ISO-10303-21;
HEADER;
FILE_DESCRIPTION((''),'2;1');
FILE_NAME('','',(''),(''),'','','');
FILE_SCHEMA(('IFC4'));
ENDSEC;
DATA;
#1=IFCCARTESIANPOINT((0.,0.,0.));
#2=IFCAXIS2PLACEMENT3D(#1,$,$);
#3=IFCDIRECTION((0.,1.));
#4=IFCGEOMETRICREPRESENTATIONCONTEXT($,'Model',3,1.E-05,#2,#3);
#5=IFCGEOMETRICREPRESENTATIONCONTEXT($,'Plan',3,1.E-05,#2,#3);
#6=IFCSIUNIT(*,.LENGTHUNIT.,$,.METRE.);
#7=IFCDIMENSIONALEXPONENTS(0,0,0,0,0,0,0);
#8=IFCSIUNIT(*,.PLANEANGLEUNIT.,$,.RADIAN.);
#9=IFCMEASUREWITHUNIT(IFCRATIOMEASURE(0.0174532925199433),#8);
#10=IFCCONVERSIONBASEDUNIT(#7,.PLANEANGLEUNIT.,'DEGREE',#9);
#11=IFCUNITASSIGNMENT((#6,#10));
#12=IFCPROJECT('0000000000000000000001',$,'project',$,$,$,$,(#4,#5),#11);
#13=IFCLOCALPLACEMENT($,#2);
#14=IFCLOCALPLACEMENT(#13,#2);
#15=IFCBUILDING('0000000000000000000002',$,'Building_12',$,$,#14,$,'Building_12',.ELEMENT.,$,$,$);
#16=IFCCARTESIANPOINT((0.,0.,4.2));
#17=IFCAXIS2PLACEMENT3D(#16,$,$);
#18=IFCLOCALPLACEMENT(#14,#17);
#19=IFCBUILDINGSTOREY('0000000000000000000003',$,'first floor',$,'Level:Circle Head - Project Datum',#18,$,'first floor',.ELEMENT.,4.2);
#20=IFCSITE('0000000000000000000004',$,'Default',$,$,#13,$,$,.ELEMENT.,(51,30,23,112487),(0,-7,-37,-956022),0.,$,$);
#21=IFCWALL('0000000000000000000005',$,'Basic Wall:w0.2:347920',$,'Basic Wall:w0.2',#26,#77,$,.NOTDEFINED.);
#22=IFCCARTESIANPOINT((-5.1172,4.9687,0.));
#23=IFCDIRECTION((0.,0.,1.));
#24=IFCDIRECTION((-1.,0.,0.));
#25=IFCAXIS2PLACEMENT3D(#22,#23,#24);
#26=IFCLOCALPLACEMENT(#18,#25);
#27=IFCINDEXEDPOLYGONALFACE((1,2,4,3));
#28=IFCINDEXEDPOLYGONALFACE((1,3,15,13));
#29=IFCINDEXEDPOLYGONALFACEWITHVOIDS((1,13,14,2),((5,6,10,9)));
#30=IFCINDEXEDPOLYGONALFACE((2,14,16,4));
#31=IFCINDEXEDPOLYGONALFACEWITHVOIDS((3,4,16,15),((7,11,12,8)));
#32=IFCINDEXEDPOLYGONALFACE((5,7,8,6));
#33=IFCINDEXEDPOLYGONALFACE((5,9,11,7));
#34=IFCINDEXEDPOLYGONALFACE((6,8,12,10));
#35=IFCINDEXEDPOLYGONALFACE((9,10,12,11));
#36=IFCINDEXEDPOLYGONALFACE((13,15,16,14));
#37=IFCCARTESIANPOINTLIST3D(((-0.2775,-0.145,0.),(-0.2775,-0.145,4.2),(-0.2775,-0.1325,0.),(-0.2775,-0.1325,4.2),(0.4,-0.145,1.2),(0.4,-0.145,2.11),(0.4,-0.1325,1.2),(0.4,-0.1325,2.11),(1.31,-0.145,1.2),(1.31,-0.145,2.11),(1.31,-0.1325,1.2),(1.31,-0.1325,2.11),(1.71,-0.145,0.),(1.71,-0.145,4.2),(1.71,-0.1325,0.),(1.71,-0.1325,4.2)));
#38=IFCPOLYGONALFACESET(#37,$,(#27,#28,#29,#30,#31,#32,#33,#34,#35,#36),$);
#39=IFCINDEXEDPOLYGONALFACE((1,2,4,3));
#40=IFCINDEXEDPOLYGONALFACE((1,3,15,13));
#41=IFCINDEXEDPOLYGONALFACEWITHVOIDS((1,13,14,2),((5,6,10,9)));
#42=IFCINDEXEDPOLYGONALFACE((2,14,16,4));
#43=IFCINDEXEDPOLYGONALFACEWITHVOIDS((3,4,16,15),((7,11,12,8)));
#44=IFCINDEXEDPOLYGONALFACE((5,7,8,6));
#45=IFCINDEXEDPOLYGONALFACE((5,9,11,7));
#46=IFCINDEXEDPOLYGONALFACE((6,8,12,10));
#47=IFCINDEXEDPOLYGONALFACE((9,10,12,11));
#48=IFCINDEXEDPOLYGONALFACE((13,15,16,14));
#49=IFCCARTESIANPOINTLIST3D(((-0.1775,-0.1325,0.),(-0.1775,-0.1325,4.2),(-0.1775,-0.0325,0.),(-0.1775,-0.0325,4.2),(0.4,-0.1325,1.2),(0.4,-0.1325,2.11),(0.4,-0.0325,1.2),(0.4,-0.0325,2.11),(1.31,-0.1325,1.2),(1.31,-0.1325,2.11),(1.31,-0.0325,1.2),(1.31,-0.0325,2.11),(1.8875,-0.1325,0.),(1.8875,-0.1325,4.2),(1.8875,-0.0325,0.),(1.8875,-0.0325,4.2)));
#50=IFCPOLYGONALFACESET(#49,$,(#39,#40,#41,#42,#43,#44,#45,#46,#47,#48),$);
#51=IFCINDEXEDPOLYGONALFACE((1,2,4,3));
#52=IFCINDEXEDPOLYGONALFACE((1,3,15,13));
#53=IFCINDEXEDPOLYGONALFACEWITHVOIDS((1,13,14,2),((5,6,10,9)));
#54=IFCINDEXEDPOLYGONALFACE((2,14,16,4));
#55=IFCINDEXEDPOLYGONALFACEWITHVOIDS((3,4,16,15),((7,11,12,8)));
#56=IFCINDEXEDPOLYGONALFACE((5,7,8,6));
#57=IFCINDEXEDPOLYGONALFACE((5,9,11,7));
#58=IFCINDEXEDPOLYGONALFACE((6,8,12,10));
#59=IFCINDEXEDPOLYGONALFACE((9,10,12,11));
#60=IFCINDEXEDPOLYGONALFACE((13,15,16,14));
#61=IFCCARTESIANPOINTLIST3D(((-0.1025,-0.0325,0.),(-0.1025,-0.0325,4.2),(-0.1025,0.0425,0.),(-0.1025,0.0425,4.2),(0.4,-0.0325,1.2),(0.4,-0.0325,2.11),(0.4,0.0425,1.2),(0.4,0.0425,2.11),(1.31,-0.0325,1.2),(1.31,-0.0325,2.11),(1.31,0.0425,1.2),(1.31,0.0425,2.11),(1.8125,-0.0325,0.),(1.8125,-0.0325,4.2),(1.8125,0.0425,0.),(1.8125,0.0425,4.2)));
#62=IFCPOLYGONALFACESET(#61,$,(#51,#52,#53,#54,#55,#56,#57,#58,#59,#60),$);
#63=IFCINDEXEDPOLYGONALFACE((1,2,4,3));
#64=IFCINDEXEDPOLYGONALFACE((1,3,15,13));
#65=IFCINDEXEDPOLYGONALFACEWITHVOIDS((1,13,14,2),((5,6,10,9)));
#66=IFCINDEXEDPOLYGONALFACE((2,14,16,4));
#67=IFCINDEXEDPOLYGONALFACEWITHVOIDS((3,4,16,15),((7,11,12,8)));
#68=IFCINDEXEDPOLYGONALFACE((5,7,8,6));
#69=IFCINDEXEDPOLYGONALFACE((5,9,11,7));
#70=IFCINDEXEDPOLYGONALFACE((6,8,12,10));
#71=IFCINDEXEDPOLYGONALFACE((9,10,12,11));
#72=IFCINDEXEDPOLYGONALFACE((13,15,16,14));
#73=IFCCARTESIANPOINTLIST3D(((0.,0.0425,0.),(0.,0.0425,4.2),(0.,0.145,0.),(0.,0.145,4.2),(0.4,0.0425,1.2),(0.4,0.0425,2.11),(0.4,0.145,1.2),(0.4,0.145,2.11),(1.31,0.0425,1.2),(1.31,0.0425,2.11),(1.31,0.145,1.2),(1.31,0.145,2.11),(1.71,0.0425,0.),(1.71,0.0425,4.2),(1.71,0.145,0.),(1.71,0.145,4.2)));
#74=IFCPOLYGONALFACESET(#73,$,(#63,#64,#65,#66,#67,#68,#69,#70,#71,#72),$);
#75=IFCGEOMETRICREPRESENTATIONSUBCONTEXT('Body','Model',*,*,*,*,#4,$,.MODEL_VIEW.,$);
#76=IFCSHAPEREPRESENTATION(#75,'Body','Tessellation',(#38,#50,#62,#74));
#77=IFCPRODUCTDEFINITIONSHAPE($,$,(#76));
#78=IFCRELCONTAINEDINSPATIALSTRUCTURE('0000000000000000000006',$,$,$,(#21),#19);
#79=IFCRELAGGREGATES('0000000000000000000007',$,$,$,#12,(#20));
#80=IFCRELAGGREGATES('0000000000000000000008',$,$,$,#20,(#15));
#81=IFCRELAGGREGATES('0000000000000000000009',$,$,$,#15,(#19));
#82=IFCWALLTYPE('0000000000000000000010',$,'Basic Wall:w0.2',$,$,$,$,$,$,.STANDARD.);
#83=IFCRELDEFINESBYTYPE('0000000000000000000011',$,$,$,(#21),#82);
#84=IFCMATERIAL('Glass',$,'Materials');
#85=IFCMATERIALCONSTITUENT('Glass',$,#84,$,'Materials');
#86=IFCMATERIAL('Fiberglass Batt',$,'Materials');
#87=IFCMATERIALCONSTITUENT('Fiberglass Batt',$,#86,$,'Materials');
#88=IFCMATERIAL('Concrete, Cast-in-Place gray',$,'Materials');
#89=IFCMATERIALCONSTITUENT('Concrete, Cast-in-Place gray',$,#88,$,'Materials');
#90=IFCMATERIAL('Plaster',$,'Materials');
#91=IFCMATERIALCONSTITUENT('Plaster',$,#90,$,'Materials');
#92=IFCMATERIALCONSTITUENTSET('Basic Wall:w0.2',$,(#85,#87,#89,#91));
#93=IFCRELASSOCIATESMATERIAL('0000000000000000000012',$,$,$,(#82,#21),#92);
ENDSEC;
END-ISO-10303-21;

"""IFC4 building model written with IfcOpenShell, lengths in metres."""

from ifc_helpers import new_model, entity, si_unit, converted_unit, direction, frame, origin, place, context, subcontext, project, spatial, indexed_curve, outline, extrude, material, constituent, constituent_set, type_object, element, save


model = new_model("IFC4")

# Units and contexts
model_context = context("Model", 3, precision=1e-05, world=origin(), true_north=direction((0.0, 1.0)))
plan_context = context("Plan", 3, precision=1e-05, world=origin(), true_north=direction((0.0, 1.0)))
body_context = subcontext(model_context, "Body", "Model", "MODEL_VIEW")
ifc_project = project(units=[si_unit("LENGTHUNIT", "METRE"), converted_unit("PLANEANGLEUNIT", "DEGREE", entity("IfcRatioMeasure", 0.0174532925199433), si_unit("PLANEANGLEUNIT", "RADIAN"), dimensions=[0, 0, 0, 0, 0, 0, 0])], contexts=[model_context, plan_context])

# Site, building, storey
site_placement = place(None, origin())
site = spatial("IfcSite", under=ifc_project, at=site_placement, Name="Default", CompositionType="ELEMENT", RefLatitude=(51, 30, 23, 112487), RefLongitude=(0, -7, -37, -956022), RefElevation=0.0)
building_placement = place(site_placement, origin())
building = spatial("IfcBuilding", under=site, at=building_placement, Name="Building_12", LongName="Building_12", CompositionType="ELEMENT")
storey_placement = place(building_placement, frame((0.0, 0.0, 4.2)))
storey = spatial("IfcBuildingStorey", under=building, at=storey_placement, Name="first floor", ObjectType="Level:Circle Head - Project Datum", LongName="first floor", CompositionType="ELEMENT", Elevation=4.2)

# Shared definitions
ifc_material_1 = material(Name="Glass", Category="Materials")
ifc_material_2 = material(Name="Plaster", Category="Materials")

# Shared definitions
ifc_material_3 = material(Name="Concrete, Cast-in-Place gray", Category="Materials")

# Wall, opening
ifc_constituent_1 = constituent(ifc_material_1, Name="Glass", Category="Materials")
ifc_material_4 = material(Name="Fiberglass Batt", Category="Materials")
ifc_constituent_2 = constituent(ifc_material_4, Name="Fiberglass Batt", Category="Materials")
ifc_constituent_3 = constituent(ifc_material_3, Name="Concrete, Cast-in-Place gray", Category="Materials")
ifc_constituent_4 = constituent(ifc_material_2, Name="Plaster", Category="Materials")
ifc_constituent_set_1 = constituent_set(constituents=[ifc_constituent_1, ifc_constituent_2, ifc_constituent_3, ifc_constituent_4], Name="Basic Wall:w0.2")
wall_type_1 = type_object("IfcWallType", Name="Basic Wall:w0.2", PredefinedType="STANDARD", material=ifc_constituent_set_1)
wall_1_placement = place(storey_placement, frame((-5.1172, 4.9687, 0.0), z_axis=(0.0, 0.0, 1.0), x_axis=(-1.0, 0.0, 0.0)))
wall_1 = element("IfcWall", 1, at=wall_1_placement, inside=storey, type_object=wall_type_1, material=ifc_constituent_set_1, Name="Basic Wall:w0.2:347920", ObjectType="Basic Wall:w0.2", PredefinedType="NOTDEFINED", context=body_context, shape_type="SweptSolid", body=[
    extrude(outline(indexed_curve([(-2.1, -0.9938), (2.1, -0.9938), (2.1, 0.9938), (-2.1, 0.9938), (-2.1, -0.9938)], self_intersect=False), holes=[indexed_curve([(0.01, 0.3163), (0.01, -0.5938), (-0.9, -0.5938), (-0.9, 0.3163), (0.01, 0.3163)], self_intersect=False)]), frame((0.7163, -0.1325, 2.1), z_axis=(0.0, -1.0, 0.0), x_axis=(0.0, 0.0, 1.0)), (0.0, 0.0, 1.0), 0.0125),
    extrude(outline(indexed_curve([(-2.1, -1.0325), (2.1, -1.0325), (2.1, 1.0325), (-2.1, 1.0325), (-2.1, -1.0325)], self_intersect=False), holes=[indexed_curve([(0.01, 0.455), (0.01, -0.455), (-0.9, -0.455), (-0.9, 0.455), (0.01, 0.455)], self_intersect=False)]), frame((0.855, -0.0325, 2.1), z_axis=(0.0, -1.0, 0.0), x_axis=(0.0, 0.0, 1.0)), (0.0, 0.0, 1.0), 0.1),
    extrude(outline(indexed_curve([(-2.1, -0.9575), (2.1, -0.9575), (2.1, 0.9575), (-2.1, 0.9575), (-2.1, -0.9575)], self_intersect=False), holes=[indexed_curve([(0.01, 0.455), (0.01, -0.455), (-0.9, -0.455), (-0.9, 0.455), (0.01, 0.455)], self_intersect=False)]), frame((0.855, 0.0425, 2.1), z_axis=(0.0, -1.0, 0.0), x_axis=(0.0, 0.0, 1.0)), (0.0, 0.0, 1.0), 0.075),
    extrude(outline(indexed_curve([(-0.855, -2.1), (0.855, -2.1), (0.855, 2.1), (-0.855, 2.1), (-0.855, -2.1)], self_intersect=False), holes=[indexed_curve([(-0.455, 0.01), (0.455, 0.01), (0.455, -0.9), (-0.455, -0.9), (-0.455, 0.01)], self_intersect=False)]), frame((0.855, 0.145, 2.1), z_axis=(0.0, -1.0, 0.0), x_axis=(1.0, 0.0, 0.0)), (0.0, 0.0, 1.0), 0.1025),
])
opening_1_placement = place(wall_1_placement, frame((0.4, -0.145, 1.2)))
element("IfcOpeningElement", 2, at=opening_1_placement, cuts=wall_1, PredefinedType="OPENING", context=body_context, shape_type="SweptSolid", body=[
    extrude(outline(indexed_curve([(0.91, 0.0), (0.91, 0.91), (0.0, 0.91), (0.0, 0.0), (0.91, 0.0)], self_intersect=False)), frame((0.0, 0.0, 0.0), z_axis=(0.0, 1.0, 0.0), x_axis=(0.0, 0.0, 1.0)), (0.0, 0.0, 1.0), 0.29),
])

save(model, "model.ifc")
